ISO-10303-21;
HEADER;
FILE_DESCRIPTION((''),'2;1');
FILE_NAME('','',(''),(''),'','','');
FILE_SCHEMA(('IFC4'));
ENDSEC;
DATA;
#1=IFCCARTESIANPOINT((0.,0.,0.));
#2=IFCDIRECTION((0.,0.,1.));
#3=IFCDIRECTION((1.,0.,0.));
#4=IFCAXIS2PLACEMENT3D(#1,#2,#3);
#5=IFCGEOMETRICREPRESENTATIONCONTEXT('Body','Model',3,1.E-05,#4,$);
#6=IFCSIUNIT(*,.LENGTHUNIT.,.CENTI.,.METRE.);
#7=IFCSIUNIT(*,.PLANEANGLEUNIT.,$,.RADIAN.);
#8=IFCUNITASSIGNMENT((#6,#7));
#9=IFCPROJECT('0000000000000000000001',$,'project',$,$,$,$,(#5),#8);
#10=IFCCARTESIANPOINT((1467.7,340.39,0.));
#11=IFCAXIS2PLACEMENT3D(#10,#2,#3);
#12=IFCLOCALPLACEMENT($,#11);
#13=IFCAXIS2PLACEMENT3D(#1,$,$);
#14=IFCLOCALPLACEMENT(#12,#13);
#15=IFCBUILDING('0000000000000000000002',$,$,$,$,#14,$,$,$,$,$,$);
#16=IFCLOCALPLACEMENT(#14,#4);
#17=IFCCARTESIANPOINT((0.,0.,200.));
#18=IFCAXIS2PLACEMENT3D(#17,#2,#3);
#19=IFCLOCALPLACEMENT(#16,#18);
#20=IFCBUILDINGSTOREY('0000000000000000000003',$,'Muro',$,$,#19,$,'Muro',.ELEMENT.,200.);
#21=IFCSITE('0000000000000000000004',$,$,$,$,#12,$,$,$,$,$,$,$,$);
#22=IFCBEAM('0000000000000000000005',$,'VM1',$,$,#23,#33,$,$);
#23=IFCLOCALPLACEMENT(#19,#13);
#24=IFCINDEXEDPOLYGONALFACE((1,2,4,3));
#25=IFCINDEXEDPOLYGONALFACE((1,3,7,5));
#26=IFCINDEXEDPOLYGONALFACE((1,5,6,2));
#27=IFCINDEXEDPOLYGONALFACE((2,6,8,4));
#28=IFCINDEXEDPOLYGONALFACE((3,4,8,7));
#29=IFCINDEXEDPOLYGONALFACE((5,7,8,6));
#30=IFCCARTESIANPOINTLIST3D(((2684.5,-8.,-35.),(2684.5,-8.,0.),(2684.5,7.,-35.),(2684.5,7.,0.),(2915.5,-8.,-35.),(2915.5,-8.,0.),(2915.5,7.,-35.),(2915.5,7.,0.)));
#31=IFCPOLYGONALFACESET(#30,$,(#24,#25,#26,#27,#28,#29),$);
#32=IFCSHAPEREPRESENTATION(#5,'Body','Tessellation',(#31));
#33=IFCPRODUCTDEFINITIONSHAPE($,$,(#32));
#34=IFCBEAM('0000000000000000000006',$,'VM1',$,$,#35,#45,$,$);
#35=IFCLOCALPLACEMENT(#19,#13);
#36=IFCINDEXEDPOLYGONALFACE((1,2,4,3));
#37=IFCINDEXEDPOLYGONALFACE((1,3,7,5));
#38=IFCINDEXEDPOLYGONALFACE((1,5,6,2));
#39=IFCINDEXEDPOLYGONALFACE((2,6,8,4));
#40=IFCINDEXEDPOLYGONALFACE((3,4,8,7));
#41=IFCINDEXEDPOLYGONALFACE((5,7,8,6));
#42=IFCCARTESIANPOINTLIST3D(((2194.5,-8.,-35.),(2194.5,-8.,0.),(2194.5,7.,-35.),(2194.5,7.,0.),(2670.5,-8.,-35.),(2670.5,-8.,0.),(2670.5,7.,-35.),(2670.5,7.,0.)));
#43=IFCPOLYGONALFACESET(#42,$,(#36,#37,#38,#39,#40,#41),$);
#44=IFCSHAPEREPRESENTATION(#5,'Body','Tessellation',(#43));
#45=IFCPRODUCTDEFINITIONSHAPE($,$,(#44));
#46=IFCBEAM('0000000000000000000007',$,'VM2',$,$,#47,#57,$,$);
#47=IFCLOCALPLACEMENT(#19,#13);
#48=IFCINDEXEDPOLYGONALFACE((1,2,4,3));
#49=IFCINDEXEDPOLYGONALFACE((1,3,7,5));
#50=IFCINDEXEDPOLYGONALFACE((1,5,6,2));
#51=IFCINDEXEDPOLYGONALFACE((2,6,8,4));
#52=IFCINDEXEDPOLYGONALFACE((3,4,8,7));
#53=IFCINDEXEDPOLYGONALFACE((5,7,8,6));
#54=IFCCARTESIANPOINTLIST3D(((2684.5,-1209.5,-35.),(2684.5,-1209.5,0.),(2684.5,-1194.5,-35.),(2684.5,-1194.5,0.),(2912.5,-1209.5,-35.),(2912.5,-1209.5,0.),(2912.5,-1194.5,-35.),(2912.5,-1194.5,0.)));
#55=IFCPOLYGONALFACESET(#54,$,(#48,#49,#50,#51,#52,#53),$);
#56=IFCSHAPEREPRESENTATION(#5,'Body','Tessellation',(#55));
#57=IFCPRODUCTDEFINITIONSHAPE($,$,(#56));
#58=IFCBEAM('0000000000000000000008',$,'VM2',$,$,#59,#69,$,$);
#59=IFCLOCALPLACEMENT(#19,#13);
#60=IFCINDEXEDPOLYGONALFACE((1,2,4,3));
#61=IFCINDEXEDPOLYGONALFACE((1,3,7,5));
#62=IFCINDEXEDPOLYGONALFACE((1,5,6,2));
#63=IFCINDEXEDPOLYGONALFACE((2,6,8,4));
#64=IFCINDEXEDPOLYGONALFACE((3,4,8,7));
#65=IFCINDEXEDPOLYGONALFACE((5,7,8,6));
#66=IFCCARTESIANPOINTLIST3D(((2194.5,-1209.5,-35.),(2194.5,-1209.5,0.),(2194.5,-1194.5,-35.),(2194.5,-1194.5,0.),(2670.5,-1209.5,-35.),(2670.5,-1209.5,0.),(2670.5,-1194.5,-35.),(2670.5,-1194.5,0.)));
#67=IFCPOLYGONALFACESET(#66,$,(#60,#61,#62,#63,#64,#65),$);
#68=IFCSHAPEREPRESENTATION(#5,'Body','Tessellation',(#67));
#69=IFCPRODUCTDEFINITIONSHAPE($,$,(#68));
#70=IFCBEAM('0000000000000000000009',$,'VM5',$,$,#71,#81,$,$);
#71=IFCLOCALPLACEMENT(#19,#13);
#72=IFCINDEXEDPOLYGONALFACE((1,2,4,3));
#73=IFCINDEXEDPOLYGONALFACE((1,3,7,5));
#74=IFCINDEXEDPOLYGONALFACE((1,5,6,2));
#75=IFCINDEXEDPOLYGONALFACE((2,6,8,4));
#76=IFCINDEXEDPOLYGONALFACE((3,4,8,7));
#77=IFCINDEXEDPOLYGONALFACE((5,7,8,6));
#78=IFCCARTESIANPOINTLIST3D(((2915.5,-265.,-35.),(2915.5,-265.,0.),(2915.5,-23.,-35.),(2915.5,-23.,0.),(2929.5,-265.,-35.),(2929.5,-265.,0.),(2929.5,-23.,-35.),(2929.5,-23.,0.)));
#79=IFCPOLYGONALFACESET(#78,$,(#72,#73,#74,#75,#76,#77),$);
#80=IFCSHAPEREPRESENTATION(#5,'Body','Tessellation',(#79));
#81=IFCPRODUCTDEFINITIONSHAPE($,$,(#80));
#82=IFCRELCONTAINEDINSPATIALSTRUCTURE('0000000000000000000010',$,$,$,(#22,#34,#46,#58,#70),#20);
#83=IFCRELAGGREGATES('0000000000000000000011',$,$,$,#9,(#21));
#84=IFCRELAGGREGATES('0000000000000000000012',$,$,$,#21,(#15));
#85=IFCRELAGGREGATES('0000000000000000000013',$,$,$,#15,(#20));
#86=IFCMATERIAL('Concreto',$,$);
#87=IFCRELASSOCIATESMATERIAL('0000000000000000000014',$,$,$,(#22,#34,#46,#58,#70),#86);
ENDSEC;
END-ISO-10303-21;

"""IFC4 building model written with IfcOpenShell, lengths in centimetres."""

from ifc_helpers import new_model, si_unit, frame, origin, origin_with_axes, origin_2d_with_axis, place, context, project, spatial, rectangle, extrude, material, element, save


model = new_model("IFC4")

# Units and contexts
model_context = context("Model", 3, precision=1e-05, world=origin_with_axes(), identifier="Body")
ifc_project = project(units=[si_unit("LENGTHUNIT", "METRE", prefix="CENTI"), si_unit("PLANEANGLEUNIT", "RADIAN")], contexts=[model_context])

# Site, building, storey
site_placement = place(None, frame((1467.7, 340.39, 0.0), z_axis=(0.0, 0.0, 1.0), x_axis=(1.0, 0.0, 0.0)))
site = spatial("IfcSite", under=ifc_project, at=site_placement)
building_placement = place(site_placement, origin())
building = spatial("IfcBuilding", under=site, at=building_placement)
placement = place(building_placement, origin_with_axes())
storey_placement = place(placement, frame((0.0, 0.0, 200.0), z_axis=(0.0, 0.0, 1.0), x_axis=(1.0, 0.0, 0.0)))
storey = spatial("IfcBuildingStorey", under=building, at=storey_placement, Name="Muro", LongName="Muro", CompositionType="ELEMENT", Elevation=200.0)

# Shared definitions
ifc_material = material(Name="Concreto")

# Beams
beam_1_placement = place(storey_placement, frame((2800.0, -0.5, 0.0), z_axis=(0.0, 0.0, 1.0), x_axis=(1.0, 0.0, 0.0)))
element("IfcBeam", 1, at=beam_1_placement, inside=storey, material=ifc_material, Name="VM1", context=model_context, shape_type="SolidModel", body=[
    extrude(rectangle(XDim=15.0, YDim=35.0, at=origin_2d_with_axis()), frame((-115.5, 0.0, -17.5), z_axis=(1.0, 0.0, 0.0), x_axis=(0.0, 1.0, 0.0)), (0.0, 0.0, 1.0), 231.0),
])
beam_2_placement = place(storey_placement, frame((2432.5, -0.5, 0.0), z_axis=(0.0, 0.0, 1.0), x_axis=(1.0, 0.0, 0.0)))
element("IfcBeam", 2, at=beam_2_placement, inside=storey, material=ifc_material, Name="VM1", context=model_context, shape_type="SolidModel", body=[
    extrude(rectangle(XDim=15.0, YDim=35.0, at=origin_2d_with_axis()), frame((-238.0, 0.0, -17.5), z_axis=(1.0, 0.0, 0.0), x_axis=(0.0, 1.0, 0.0)), (0.0, 0.0, 1.0), 476.0),
])
beam_3_placement = place(storey_placement, frame((2798.5, -1202.0, 0.0), z_axis=(0.0, 0.0, 1.0), x_axis=(1.0, 0.0, 0.0)))
element("IfcBeam", 3, at=beam_3_placement, inside=storey, material=ifc_material, Name="VM2", context=model_context, shape_type="SolidModel", body=[
    extrude(rectangle(XDim=15.0, YDim=35.0, at=origin_2d_with_axis()), frame((-114.0, 0.0, -17.5), z_axis=(1.0, 0.0, 0.0), x_axis=(0.0, 1.0, 0.0)), (0.0, 0.0, 1.0), 228.0),
])
beam_4_placement = place(storey_placement, frame((2432.5, -1202.0, 0.0), z_axis=(0.0, 0.0, 1.0), x_axis=(1.0, 0.0, 0.0)))
element("IfcBeam", 4, at=beam_4_placement, inside=storey, material=ifc_material, Name="VM2", context=model_context, shape_type="SolidModel", body=[
    extrude(rectangle(XDim=15.0, YDim=35.0, at=origin_2d_with_axis()), frame((-238.0, 0.0, -17.5), z_axis=(1.0, 0.0, 0.0), x_axis=(0.0, 1.0, 0.0)), (0.0, 0.0, 1.0), 476.0),
])
beam_5_placement = place(storey_placement, frame((2922.5, -144.0, 0.0), z_axis=(0.0, 0.0, 1.0), x_axis=(1.0, 0.0, 0.0)))
element("IfcBeam", 5, at=beam_5_placement, inside=storey, material=ifc_material, Name="VM5", context=model_context, shape_type="SolidModel", body=[
    extrude(rectangle(XDim=14.0, YDim=35.0, at=origin_2d_with_axis()), frame((0.0, -121.0, -17.5), z_axis=(0.0, 1.0, 0.0), x_axis=(1.0, 0.0, 0.0)), (0.0, 0.0, 1.0), 242.0),
])

save(model, "model.ifc")
